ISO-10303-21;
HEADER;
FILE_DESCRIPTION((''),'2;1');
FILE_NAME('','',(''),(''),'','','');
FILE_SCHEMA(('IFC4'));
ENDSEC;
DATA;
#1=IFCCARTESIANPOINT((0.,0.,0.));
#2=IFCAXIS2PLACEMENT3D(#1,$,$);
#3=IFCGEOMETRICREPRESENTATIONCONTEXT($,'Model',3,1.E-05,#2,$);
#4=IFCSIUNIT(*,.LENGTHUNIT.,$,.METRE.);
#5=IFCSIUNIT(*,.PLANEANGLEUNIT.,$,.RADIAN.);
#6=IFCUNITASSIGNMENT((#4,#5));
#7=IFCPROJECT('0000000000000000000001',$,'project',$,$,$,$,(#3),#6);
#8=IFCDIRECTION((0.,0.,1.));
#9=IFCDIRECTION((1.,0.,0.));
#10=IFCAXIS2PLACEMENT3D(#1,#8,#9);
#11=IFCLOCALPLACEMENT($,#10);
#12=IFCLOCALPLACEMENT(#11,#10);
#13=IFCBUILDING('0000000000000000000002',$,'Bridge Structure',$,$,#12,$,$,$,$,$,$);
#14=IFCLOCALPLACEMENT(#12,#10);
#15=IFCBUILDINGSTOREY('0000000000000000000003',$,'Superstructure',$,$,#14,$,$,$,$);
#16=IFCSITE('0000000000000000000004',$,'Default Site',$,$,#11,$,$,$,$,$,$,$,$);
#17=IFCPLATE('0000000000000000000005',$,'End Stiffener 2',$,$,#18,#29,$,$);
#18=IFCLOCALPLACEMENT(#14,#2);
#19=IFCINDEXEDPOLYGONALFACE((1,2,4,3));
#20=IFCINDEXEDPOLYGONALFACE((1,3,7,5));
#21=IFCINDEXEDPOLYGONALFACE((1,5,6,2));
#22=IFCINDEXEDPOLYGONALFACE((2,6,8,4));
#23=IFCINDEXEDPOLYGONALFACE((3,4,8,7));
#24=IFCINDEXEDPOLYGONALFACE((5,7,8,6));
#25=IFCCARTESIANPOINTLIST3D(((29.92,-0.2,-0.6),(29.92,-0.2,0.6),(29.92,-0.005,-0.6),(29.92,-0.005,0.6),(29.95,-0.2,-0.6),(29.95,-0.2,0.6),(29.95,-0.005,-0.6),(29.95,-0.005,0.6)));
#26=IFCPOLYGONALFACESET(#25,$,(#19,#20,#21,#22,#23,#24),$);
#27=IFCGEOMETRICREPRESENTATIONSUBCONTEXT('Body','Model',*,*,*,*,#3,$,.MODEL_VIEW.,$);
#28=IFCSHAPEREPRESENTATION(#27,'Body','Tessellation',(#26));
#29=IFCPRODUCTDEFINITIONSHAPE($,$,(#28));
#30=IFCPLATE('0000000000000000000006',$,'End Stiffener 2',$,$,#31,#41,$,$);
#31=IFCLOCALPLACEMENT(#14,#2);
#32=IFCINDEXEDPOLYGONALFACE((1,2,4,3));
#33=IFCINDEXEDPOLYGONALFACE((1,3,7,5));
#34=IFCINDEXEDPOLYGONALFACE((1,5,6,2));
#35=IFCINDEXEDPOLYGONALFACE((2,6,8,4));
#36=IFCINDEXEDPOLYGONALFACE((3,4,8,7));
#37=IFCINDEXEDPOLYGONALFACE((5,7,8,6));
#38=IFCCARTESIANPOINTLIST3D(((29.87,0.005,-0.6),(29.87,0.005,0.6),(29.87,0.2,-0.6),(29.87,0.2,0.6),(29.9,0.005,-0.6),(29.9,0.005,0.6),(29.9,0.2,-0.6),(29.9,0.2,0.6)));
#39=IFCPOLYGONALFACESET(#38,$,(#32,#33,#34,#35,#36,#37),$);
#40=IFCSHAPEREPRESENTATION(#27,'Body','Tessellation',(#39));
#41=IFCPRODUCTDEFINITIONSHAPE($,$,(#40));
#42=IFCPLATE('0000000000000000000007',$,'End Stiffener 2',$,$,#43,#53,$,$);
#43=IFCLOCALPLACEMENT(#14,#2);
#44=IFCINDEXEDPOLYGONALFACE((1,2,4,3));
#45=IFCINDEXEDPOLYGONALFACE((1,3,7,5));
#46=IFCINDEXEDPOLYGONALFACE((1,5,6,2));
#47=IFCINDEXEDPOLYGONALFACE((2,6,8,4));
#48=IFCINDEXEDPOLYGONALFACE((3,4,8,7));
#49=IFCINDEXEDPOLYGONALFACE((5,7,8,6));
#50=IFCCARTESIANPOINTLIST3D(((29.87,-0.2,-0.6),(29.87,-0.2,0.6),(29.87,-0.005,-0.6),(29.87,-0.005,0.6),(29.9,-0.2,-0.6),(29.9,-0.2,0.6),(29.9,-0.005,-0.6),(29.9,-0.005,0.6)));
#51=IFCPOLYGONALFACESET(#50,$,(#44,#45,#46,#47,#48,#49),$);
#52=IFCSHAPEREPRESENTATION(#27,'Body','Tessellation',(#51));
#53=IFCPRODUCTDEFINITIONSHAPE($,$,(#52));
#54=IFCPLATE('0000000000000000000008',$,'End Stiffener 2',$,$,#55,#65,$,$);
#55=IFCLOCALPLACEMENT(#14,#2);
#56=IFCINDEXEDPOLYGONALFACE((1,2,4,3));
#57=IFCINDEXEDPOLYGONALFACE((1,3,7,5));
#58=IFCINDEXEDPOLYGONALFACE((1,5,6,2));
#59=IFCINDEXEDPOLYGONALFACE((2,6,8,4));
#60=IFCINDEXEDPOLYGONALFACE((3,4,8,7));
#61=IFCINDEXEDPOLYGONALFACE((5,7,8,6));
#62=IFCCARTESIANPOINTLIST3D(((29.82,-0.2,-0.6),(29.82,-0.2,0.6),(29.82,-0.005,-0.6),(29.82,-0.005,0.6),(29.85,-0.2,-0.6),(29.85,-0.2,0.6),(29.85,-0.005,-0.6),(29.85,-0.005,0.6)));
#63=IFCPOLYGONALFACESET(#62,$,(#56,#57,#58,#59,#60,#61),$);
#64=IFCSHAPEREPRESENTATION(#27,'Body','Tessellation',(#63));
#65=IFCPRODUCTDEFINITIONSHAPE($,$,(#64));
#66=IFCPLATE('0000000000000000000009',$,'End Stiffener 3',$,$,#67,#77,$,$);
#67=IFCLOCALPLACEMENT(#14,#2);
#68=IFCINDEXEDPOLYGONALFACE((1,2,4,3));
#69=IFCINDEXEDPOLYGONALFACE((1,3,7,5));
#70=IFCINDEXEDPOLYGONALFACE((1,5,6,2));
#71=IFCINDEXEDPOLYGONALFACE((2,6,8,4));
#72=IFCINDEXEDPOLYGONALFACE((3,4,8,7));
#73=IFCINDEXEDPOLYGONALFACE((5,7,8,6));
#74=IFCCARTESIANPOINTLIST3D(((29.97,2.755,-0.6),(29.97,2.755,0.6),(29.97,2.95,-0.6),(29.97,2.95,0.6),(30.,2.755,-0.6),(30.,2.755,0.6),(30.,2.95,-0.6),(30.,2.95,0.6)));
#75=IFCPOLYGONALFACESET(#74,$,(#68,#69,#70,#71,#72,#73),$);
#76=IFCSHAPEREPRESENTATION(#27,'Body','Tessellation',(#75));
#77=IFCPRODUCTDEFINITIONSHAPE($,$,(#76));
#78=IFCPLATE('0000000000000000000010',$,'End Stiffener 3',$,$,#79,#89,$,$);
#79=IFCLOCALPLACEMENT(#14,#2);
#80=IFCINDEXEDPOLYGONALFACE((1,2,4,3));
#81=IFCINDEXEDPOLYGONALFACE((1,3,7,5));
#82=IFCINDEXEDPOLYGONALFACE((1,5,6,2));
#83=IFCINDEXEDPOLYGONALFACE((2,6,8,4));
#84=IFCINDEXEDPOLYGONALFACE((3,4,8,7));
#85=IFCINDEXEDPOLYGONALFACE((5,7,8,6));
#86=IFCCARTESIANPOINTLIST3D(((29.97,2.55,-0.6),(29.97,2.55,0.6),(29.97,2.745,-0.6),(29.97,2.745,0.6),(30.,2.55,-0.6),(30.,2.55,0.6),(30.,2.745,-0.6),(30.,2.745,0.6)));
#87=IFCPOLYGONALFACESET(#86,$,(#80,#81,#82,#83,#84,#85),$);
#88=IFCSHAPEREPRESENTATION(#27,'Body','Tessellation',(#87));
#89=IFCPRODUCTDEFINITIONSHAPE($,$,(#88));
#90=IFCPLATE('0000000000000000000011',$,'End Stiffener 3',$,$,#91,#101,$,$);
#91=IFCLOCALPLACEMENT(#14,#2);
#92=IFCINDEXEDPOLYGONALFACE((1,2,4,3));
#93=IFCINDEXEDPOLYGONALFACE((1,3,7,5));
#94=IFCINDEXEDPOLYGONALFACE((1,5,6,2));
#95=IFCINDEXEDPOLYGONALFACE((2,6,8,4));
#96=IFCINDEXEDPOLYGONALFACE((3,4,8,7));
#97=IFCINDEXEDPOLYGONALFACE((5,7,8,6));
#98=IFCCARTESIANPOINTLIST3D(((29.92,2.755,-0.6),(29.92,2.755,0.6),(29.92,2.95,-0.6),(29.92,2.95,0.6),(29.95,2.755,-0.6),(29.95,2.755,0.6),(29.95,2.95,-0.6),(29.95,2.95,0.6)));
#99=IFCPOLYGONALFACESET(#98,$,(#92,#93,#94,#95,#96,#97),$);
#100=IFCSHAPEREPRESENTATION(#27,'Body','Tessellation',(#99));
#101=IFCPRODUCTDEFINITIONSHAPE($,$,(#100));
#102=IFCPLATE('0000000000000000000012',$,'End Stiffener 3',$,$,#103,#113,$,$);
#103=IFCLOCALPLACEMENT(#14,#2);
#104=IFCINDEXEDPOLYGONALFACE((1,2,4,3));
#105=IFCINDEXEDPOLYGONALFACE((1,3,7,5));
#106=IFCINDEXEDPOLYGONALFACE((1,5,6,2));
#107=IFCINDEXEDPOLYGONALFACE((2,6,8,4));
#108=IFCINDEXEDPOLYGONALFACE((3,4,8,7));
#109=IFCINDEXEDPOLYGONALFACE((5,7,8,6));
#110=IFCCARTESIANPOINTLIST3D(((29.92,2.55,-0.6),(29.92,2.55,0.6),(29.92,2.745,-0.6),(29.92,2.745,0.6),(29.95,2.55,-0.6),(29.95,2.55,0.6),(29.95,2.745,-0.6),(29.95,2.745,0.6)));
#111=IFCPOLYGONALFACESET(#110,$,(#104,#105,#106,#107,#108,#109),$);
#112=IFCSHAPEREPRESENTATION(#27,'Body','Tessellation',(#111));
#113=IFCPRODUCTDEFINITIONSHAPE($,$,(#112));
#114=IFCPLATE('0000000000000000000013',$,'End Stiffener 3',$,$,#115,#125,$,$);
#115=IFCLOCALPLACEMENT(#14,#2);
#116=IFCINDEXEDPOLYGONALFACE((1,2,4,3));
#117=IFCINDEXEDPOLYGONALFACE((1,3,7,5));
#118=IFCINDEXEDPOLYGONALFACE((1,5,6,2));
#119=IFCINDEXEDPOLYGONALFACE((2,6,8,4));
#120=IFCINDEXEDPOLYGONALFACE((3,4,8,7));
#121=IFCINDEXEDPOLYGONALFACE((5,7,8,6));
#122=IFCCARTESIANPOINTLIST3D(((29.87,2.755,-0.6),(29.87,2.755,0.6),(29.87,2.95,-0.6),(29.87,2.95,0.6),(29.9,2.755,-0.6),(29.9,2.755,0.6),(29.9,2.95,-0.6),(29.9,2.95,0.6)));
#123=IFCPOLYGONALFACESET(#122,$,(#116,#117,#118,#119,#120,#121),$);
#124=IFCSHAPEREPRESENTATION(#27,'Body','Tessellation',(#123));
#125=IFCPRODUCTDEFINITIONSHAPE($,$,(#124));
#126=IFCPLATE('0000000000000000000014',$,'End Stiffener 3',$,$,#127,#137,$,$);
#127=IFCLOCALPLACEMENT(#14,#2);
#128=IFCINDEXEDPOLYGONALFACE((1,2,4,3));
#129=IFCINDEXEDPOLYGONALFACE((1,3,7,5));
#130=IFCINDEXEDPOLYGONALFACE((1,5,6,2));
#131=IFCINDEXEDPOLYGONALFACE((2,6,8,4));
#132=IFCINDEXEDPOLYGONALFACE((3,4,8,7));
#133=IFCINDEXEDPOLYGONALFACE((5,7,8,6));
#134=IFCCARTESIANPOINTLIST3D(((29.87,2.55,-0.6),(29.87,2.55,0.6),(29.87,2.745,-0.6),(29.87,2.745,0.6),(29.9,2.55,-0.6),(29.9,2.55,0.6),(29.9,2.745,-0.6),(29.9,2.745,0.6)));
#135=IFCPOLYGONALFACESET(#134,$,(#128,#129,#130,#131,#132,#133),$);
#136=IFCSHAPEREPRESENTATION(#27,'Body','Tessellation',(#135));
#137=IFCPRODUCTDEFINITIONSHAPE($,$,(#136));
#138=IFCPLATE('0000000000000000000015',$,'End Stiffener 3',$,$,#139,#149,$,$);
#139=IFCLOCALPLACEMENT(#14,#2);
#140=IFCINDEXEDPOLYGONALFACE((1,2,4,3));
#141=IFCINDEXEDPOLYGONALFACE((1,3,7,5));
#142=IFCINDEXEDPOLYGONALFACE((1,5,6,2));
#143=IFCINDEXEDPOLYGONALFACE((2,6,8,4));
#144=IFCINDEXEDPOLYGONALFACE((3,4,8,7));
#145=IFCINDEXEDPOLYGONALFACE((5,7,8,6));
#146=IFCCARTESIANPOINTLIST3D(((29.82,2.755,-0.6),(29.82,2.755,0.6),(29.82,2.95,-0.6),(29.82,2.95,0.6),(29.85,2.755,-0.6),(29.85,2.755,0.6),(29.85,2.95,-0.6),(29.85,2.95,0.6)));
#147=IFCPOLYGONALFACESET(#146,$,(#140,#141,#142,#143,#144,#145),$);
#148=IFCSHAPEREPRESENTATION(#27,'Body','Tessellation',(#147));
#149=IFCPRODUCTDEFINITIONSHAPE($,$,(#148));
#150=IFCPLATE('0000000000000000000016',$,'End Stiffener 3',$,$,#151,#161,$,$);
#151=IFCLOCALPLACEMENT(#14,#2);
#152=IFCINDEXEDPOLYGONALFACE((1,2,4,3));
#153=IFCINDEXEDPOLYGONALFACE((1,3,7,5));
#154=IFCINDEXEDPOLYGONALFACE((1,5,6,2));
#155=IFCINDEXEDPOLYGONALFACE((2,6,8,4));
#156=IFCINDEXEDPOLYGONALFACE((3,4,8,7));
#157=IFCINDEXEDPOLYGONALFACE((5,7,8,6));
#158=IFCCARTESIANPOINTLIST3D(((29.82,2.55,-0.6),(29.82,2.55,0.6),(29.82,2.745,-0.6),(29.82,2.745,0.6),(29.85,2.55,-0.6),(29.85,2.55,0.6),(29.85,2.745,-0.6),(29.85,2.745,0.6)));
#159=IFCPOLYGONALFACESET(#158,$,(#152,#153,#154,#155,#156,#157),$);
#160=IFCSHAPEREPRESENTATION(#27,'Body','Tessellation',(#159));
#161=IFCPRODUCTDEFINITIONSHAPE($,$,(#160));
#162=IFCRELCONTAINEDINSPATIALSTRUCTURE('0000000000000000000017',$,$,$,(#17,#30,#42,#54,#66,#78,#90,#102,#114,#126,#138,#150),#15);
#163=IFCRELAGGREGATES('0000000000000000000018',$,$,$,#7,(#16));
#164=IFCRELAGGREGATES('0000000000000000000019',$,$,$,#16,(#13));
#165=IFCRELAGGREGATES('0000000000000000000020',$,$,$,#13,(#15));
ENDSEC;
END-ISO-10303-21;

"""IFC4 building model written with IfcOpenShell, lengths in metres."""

from ifc_helpers import new_model, si_unit, frame, origin, origin_with_axes, origin_2d_with_axis, place, context, subcontext, project, spatial, rectangle, extrude, element, save


model = new_model("IFC4")

# Units and contexts
model_context = context("Model", 3, precision=1e-05, world=origin())
body_context = subcontext(model_context, "Body", "Model", "MODEL_VIEW")
ifc_project = project(units=[si_unit("LENGTHUNIT", "METRE"), si_unit("PLANEANGLEUNIT", "RADIAN")], contexts=[model_context])

# Site, building, storey
site_placement = place(None, origin_with_axes())
site = spatial("IfcSite", under=ifc_project, at=site_placement, Name="Default Site")
building_placement = place(site_placement, origin_with_axes())
building = spatial("IfcBuilding", under=site, at=building_placement, Name="Bridge Structure")
storey_placement = place(building_placement, origin_with_axes())
storey = spatial("IfcBuildingStorey", under=building, at=storey_placement, Name="Superstructure")

# Plates
for number, where, z_axis, x_axis, name in (
    (1, (29.935, -0.1025, -0.6), (0.0, 0.0, 1.0), (1.0, 0.0, 0.0), "End Stiffener 2"),
    (2, (29.885, 0.1025, -0.6), (0.0, 0.0, 1.0), (1.0, 0.0, 0.0), "End Stiffener 2"),
    (3, (29.885, -0.1025, -0.6), (0.0, 0.0, 1.0), (1.0, 0.0, 0.0), "End Stiffener 2"),
    (4, (29.835, -0.1025, -0.6), (0.0, 0.0, 1.0), (1.0, 0.0, 0.0), "End Stiffener 2"),
    (5, (29.985, 2.8525, -0.6), (0.0, 0.0, 1.0), (1.0, 0.0, 0.0), "End Stiffener 3"),
    (6, (29.985, 2.6475, -0.6), (0.0, 0.0, 1.0), (1.0, 0.0, 0.0), "End Stiffener 3"),
    (7, (29.935, 2.8525, -0.6), (0.0, 0.0, 1.0), (1.0, 0.0, 0.0), "End Stiffener 3"),
    (8, (29.935, 2.6475, -0.6), (0.0, 0.0, 1.0), (1.0, 0.0, 0.0), "End Stiffener 3"),
    (9, (29.885, 2.8525, -0.6), (0.0, 0.0, 1.0), (1.0, 0.0, 0.0), "End Stiffener 3"),
    (10, (29.885, 2.6475, -0.6), (0.0, 0.0, 1.0), (1.0, 0.0, 0.0), "End Stiffener 3"),
    (11, (29.835, 2.8525, -0.6), (0.0, 0.0, 1.0), (1.0, 0.0, 0.0), "End Stiffener 3"),
    (12, (29.835, 2.6475, -0.6), (0.0, 0.0, 1.0), (1.0, 0.0, 0.0), "End Stiffener 3"),
):
    element("IfcPlate", number, at=place(storey_placement, frame(where, z_axis=z_axis, x_axis=x_axis)), inside=storey, Name=name, context=body_context, shape_type="SweptSolid", body=[
        extrude(rectangle(XDim=0.03, YDim=0.195, at=origin_2d_with_axis()), origin_with_axes(), (0.0, 0.0, 1.0), 1.2),
    ])

save(model, "model.ifc")
